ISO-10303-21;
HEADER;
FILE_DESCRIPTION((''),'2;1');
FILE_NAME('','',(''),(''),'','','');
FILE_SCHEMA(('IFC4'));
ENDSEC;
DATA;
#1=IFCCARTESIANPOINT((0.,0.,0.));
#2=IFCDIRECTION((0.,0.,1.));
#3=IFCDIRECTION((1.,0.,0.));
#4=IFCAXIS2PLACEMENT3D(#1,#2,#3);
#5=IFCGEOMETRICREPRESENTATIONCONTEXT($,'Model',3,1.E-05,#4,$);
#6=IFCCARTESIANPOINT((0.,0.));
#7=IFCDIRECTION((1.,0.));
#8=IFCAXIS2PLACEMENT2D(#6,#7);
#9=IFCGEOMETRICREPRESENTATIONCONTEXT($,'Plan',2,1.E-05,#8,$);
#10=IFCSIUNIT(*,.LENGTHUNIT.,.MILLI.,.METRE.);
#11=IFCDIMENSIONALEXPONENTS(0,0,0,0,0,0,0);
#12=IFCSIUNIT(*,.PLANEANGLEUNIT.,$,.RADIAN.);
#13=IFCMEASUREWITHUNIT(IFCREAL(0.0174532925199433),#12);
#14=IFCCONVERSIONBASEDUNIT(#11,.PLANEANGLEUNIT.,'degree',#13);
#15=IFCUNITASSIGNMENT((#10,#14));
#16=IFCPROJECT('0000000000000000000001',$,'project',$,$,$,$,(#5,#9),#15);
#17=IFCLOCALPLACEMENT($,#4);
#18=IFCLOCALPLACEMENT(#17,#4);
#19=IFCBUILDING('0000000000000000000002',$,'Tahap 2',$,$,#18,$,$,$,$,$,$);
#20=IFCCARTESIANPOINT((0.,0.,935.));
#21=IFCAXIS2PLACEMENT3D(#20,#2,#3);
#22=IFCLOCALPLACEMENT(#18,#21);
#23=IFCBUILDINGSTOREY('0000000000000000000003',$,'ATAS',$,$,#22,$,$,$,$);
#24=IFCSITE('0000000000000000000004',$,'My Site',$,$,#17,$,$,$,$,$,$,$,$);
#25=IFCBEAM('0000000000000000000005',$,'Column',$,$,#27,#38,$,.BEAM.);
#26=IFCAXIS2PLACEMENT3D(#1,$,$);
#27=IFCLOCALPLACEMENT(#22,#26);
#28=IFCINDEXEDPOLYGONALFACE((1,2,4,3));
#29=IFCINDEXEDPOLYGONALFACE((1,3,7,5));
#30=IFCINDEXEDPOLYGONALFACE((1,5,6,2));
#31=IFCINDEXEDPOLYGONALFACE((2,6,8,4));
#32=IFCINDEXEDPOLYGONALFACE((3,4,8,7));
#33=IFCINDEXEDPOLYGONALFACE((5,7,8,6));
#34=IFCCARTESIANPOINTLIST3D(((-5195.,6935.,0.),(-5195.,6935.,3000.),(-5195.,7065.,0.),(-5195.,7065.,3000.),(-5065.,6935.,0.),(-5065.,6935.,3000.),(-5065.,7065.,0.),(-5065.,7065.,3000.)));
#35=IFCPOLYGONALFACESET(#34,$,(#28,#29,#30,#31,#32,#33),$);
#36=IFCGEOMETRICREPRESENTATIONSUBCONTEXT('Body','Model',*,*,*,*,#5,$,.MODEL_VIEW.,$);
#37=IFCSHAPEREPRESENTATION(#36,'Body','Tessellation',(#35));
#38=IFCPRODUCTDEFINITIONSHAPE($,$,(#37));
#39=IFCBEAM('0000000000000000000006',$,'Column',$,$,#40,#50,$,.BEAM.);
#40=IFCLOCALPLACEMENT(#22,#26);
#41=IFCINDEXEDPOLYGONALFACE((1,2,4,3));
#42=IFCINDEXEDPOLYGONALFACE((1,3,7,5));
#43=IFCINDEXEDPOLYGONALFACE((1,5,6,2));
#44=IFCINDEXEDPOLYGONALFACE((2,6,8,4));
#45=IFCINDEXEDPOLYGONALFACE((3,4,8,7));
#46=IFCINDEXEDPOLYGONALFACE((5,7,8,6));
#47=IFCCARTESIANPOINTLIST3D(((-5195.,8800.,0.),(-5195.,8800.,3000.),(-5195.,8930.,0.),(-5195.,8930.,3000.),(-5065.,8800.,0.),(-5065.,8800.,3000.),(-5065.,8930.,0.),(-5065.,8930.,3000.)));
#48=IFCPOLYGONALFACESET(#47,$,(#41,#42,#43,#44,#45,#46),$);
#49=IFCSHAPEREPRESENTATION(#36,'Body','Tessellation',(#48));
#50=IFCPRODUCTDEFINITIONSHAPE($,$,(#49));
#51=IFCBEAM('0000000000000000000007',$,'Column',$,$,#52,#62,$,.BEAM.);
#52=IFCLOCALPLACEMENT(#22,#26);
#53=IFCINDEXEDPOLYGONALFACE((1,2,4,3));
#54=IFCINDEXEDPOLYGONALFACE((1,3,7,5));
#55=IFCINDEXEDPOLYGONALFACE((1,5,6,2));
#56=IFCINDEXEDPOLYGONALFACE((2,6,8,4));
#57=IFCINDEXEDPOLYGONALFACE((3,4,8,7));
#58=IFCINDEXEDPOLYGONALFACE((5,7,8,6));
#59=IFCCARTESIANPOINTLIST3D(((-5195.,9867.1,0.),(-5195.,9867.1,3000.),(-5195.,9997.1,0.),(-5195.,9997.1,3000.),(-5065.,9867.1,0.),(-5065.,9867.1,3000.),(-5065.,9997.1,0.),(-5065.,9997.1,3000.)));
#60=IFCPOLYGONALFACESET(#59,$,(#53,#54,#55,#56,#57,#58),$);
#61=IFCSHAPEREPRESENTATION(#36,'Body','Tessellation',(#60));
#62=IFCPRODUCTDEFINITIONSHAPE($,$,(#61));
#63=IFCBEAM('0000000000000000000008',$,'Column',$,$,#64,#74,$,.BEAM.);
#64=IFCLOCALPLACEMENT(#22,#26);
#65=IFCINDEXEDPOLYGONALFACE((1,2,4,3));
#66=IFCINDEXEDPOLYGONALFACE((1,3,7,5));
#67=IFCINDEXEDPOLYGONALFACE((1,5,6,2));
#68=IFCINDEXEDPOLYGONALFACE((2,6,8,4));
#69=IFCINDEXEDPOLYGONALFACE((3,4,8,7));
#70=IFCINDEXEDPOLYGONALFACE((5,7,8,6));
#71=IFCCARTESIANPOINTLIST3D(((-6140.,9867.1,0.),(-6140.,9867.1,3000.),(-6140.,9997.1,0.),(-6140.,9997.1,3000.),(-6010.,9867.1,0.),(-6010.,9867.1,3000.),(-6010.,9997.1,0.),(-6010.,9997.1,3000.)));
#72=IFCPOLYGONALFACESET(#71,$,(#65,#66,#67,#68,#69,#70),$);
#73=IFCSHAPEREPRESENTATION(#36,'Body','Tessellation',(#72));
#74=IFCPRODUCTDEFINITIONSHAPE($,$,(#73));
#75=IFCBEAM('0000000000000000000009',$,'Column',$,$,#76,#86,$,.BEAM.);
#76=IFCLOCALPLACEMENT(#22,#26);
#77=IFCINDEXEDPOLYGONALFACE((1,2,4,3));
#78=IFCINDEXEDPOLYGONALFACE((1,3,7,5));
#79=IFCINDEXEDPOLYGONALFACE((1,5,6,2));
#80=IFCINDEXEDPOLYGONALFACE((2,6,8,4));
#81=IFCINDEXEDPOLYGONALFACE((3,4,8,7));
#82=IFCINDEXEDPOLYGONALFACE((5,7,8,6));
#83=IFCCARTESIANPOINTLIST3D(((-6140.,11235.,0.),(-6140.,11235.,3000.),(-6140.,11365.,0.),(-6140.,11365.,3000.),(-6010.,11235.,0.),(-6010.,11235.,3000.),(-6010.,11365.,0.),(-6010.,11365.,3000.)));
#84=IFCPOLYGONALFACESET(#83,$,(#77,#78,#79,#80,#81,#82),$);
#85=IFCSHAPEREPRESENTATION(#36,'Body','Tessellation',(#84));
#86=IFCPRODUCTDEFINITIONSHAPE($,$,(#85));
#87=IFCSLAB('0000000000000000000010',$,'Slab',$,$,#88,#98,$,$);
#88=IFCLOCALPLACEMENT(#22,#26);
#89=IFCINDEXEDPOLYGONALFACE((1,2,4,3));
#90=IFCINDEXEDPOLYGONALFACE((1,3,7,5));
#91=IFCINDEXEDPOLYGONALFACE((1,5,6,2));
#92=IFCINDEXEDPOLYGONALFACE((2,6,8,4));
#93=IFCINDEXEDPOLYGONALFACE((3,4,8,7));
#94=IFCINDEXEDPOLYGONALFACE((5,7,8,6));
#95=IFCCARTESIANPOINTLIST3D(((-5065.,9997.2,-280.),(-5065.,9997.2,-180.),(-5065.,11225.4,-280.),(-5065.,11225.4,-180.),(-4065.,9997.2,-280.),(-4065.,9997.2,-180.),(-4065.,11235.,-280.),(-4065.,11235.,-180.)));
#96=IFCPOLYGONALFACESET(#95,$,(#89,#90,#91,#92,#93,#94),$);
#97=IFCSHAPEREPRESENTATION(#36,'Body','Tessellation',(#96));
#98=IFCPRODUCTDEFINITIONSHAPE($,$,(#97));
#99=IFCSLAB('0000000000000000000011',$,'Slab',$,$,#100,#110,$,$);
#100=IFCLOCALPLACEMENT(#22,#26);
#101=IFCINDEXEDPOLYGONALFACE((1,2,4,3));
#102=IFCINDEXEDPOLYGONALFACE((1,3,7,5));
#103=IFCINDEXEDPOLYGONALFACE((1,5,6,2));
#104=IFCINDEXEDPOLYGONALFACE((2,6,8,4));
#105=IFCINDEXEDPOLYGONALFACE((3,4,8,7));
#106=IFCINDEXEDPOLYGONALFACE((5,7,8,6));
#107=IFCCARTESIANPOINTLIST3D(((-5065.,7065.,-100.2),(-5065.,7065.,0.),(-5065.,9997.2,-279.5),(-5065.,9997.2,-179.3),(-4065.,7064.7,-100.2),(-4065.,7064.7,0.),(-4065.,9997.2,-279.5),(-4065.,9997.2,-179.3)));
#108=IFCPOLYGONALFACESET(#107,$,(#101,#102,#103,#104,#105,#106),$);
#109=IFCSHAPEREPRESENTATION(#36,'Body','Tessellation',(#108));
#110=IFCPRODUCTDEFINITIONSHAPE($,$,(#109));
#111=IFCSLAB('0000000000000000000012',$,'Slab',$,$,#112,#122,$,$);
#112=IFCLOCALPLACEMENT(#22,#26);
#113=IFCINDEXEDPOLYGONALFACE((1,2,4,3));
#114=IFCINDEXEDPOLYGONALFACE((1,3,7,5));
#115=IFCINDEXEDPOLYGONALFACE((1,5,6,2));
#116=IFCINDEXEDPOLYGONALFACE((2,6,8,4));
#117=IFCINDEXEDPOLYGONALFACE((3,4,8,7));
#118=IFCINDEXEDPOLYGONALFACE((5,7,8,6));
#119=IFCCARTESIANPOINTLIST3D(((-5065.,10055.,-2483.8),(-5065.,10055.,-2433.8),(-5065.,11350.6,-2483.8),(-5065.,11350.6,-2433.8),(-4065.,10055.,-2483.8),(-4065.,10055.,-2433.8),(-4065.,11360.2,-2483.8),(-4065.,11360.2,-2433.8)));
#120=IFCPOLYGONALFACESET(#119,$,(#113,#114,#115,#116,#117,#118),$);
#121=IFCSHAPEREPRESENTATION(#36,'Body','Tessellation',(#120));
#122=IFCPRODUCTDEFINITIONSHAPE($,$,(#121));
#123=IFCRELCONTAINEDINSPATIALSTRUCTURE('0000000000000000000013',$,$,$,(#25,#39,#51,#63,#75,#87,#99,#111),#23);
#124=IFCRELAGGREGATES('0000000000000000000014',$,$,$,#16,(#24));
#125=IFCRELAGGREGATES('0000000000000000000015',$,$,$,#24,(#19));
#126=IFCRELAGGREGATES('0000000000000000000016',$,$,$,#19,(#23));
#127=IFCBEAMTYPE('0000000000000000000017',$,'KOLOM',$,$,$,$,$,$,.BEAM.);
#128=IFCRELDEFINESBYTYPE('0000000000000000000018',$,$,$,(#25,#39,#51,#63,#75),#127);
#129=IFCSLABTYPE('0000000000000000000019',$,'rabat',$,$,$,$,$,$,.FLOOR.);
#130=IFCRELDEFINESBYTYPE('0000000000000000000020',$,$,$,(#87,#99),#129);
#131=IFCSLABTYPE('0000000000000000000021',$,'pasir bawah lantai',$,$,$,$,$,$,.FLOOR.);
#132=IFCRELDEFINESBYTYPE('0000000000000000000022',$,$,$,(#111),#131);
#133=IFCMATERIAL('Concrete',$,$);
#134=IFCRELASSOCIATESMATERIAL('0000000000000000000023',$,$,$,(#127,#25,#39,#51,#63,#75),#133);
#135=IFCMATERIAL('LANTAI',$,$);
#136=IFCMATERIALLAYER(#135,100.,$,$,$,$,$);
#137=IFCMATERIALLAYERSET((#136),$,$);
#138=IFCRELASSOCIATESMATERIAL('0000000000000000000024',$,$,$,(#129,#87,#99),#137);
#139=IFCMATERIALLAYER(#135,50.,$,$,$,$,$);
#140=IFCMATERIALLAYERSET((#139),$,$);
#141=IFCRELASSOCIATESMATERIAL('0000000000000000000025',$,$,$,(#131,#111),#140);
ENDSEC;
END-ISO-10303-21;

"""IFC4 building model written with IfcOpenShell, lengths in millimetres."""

from ifc_helpers import new_model, entity, si_unit, converted_unit, frame, origin_with_axes, origin_2d_with_axis, place, context, subcontext, project, spatial, indexed_curve, rectangle, outline, extrude, material, layer, layer_set, layer_usage, material_profile, profile_set, profile_usage, type_object, element, save


model = new_model("IFC4")

# Units and contexts
model_context = context("Model", 3, precision=1e-05, world=origin_with_axes())
plan_context = context("Plan", 2, precision=1e-05, world=origin_2d_with_axis())
body_context_1 = subcontext(model_context, "Body", "Model", "MODEL_VIEW")
ifc_project = project(units=[si_unit("LENGTHUNIT", "METRE", prefix="MILLI"), converted_unit("PLANEANGLEUNIT", "degree", entity("IfcReal", 0.0174532925199433), si_unit("PLANEANGLEUNIT", "RADIAN"), dimensions=[0, 0, 0, 0, 0, 0, 0])], contexts=[model_context, plan_context])

# Site, building, storey
site_placement = place(None, origin_with_axes())
site = spatial("IfcSite", under=ifc_project, at=site_placement, Name="My Site")
building_placement = place(site_placement, origin_with_axes())
building = spatial("IfcBuilding", under=site, at=building_placement, Name="Tahap 2")
storey_placement = place(building_placement, frame((0.0, 0.0, 935.0), z_axis=(0.0, 0.0, 1.0), x_axis=(1.0, 0.0, 0.0)))
storey = spatial("IfcBuildingStorey", under=building, at=storey_placement, Name="ATAS")

# Beams
ifc_material_1 = material(Name="Concrete")
ifc_material_profile = material_profile(ifc_material_1, rectangle(XDim=130.0, YDim=130.0, kind="CURVE"))
ifc_profile_set = profile_set([ifc_material_profile])
ifc_profile_usage_1 = profile_usage(ifc_profile_set, cardinal=2)
beam_type = type_object("IfcBeamType", Name="KOLOM", PredefinedType="BEAM", material=ifc_profile_set)
beam_1_placement = place(storey_placement, frame((-5130.0, 6935.0, 0.0), z_axis=(0.0, 0.0, 1.0), x_axis=(1.0, 0.0, 0.0)))
element("IfcBeam", 1, at=beam_1_placement, inside=storey, type_object=beam_type, material=ifc_profile_usage_1, Name="Column", PredefinedType="BEAM", context=body_context_1, shape_type="SweptSolid", body=[
    extrude(rectangle(XDim=130.0, YDim=130.0, kind="CURVE"), frame((0.0, 65.0, 0.0), z_axis=(0.0, 0.0, 1.0), x_axis=(1.0, 0.0, 0.0)), (0.0, 0.0, 1.0), 3000.0),
])
ifc_profile_usage_2 = profile_usage(ifc_profile_set, cardinal=2)
beam_2_placement = place(storey_placement, frame((-5130.0, 8800.0, 0.0), z_axis=(0.0, 0.0, 1.0), x_axis=(1.0, 0.0, 0.0)))
element("IfcBeam", 2, at=beam_2_placement, inside=storey, type_object=beam_type, material=ifc_profile_usage_2, Name="Column", PredefinedType="BEAM", context=body_context_1, shape_type="SweptSolid", body=[
    extrude(rectangle(XDim=130.0, YDim=130.0, kind="CURVE"), frame((0.0, 65.0, 0.0), z_axis=(0.0, 0.0, 1.0), x_axis=(1.0, 0.0, 0.0)), (0.0, 0.0, 1.0), 3000.0),
])
ifc_profile_usage_3 = profile_usage(ifc_profile_set, cardinal=2)
beam_3_placement = place(storey_placement, frame((-5130.0, 9867.1, 0.0), z_axis=(0.0, 0.0, 1.0), x_axis=(1.0, 0.0, 0.0)))
element("IfcBeam", 3, at=beam_3_placement, inside=storey, type_object=beam_type, material=ifc_profile_usage_3, Name="Column", PredefinedType="BEAM", context=body_context_1, shape_type="SweptSolid", body=[
    extrude(rectangle(XDim=130.0, YDim=130.0, kind="CURVE"), frame((0.0, 65.0, 0.0), z_axis=(0.0, 0.0, 1.0), x_axis=(1.0, 0.0, 0.0)), (0.0, 0.0, 1.0), 3000.0),
])
ifc_profile_usage_4 = profile_usage(ifc_profile_set, cardinal=2)
beam_4_placement = place(storey_placement, frame((-6075.0, 9867.1, 0.0), z_axis=(0.0, 0.0, 1.0), x_axis=(1.0, 0.0, 0.0)))
element("IfcBeam", 4, at=beam_4_placement, inside=storey, type_object=beam_type, material=ifc_profile_usage_4, Name="Column", PredefinedType="BEAM", context=body_context_1, shape_type="SweptSolid", body=[
    extrude(rectangle(XDim=130.0, YDim=130.0, kind="CURVE"), frame((0.0, 65.0, 0.0), z_axis=(0.0, 0.0, 1.0), x_axis=(1.0, 0.0, 0.0)), (0.0, 0.0, 1.0), 3000.0),
])
ifc_profile_usage_5 = profile_usage(ifc_profile_set, cardinal=2)
beam_5_placement = place(storey_placement, frame((-6075.0, 11235.0, 0.0), z_axis=(0.0, 0.0, 1.0), x_axis=(1.0, 0.0, 0.0)))
element("IfcBeam", 5, at=beam_5_placement, inside=storey, type_object=beam_type, material=ifc_profile_usage_5, Name="Column", PredefinedType="BEAM", context=body_context_1, shape_type="SweptSolid", body=[
    extrude(rectangle(XDim=130.0, YDim=130.0, kind="CURVE"), frame((0.0, 65.0, 0.0), z_axis=(0.0, 0.0, 1.0), x_axis=(1.0, 0.0, 0.0)), (0.0, 0.0, 1.0), 3000.0),
])

# Slabs
ifc_material_2 = material(Name="LANTAI")
ifc_layer_1 = layer(ifc_material_2, 100.0)
ifc_layer_set_1 = layer_set([ifc_layer_1])
ifc_layer_usage_1 = layer_usage(ifc_layer_set_1, "AXIS3", "NEGATIVE", 0.0)
slab_type_1 = type_object("IfcSlabType", Name="rabat", PredefinedType="FLOOR", material=ifc_layer_set_1)
slab_1_placement = place(storey_placement, frame((-4065.0, 11235.0, -180.0), z_axis=(0.0, 0.0, 1.0), x_axis=(1.0, 0.0, 0.0)))
element("IfcSlab", 6, at=slab_1_placement, inside=storey, type_object=slab_type_1, material=ifc_layer_usage_1, Name="Slab", context=body_context_1, shape_type="SweptSolid", body=[
    extrude(outline(indexed_curve([(0.0, -1237.8), (-1000.0, -1237.8), (-1000.0, -9.6), (0.0, 0.0), (0.0, -1237.8)])), None, (0.0, 0.0, -1.0), 100.0),
])
ifc_layer_usage_2 = layer_usage(ifc_layer_set_1, "AXIS3", "NEGATIVE", 0.0)
slab_2_placement = place(storey_placement, frame((-5065.0, 7065.0, 0.0), z_axis=(0.0, 0.061048, 0.998135), x_axis=(1.0, 0.0, 0.0)))
element("IfcSlab", 7, at=slab_2_placement, inside=storey, type_object=slab_type_1, material=ifc_layer_usage_2, Name="Slab", context=body_context_1, shape_type="SweptSolid", body=[
    extrude(outline(indexed_curve([(1000.0, -0.3), (1000.0, 2937.7), (0.0, 2937.7), (0.0, 0.0), (1000.0, -0.3)])), None, (0.0, 0.061049, -0.998135), 100.2),
])
ifc_layer_2 = layer(ifc_material_2, 50.0)
ifc_layer_set_2 = layer_set([ifc_layer_2])
ifc_layer_usage_3 = layer_usage(ifc_layer_set_2, "AXIS3", "POSITIVE", -50.0)
slab_type_2 = type_object("IfcSlabType", Name="pasir bawah lantai", PredefinedType="FLOOR", material=ifc_layer_set_2)
slab_3_placement = place(storey_placement, frame((-4065.0, 11360.2, -2433.8), z_axis=(0.0, 0.0, 1.0), x_axis=(1.0, 0.0, 0.0)))
element("IfcSlab", 8, at=slab_3_placement, inside=storey, type_object=slab_type_2, material=ifc_layer_usage_3, Name="Slab", context=body_context_1, shape_type="SweptSolid", body=[
    extrude(outline(indexed_curve([(0.0, -1305.2), (-1000.0, -1305.2), (-1000.0, -9.6), (0.0, 0.0), (0.0, -1305.2)])), frame((0.0, 0.0, -50.0), z_axis=(0.0, 0.0, 1.0), x_axis=(1.0, 0.0, 0.0)), (0.0, 0.0, 1.0), 50.0),
])

save(model, "model.ifc")
